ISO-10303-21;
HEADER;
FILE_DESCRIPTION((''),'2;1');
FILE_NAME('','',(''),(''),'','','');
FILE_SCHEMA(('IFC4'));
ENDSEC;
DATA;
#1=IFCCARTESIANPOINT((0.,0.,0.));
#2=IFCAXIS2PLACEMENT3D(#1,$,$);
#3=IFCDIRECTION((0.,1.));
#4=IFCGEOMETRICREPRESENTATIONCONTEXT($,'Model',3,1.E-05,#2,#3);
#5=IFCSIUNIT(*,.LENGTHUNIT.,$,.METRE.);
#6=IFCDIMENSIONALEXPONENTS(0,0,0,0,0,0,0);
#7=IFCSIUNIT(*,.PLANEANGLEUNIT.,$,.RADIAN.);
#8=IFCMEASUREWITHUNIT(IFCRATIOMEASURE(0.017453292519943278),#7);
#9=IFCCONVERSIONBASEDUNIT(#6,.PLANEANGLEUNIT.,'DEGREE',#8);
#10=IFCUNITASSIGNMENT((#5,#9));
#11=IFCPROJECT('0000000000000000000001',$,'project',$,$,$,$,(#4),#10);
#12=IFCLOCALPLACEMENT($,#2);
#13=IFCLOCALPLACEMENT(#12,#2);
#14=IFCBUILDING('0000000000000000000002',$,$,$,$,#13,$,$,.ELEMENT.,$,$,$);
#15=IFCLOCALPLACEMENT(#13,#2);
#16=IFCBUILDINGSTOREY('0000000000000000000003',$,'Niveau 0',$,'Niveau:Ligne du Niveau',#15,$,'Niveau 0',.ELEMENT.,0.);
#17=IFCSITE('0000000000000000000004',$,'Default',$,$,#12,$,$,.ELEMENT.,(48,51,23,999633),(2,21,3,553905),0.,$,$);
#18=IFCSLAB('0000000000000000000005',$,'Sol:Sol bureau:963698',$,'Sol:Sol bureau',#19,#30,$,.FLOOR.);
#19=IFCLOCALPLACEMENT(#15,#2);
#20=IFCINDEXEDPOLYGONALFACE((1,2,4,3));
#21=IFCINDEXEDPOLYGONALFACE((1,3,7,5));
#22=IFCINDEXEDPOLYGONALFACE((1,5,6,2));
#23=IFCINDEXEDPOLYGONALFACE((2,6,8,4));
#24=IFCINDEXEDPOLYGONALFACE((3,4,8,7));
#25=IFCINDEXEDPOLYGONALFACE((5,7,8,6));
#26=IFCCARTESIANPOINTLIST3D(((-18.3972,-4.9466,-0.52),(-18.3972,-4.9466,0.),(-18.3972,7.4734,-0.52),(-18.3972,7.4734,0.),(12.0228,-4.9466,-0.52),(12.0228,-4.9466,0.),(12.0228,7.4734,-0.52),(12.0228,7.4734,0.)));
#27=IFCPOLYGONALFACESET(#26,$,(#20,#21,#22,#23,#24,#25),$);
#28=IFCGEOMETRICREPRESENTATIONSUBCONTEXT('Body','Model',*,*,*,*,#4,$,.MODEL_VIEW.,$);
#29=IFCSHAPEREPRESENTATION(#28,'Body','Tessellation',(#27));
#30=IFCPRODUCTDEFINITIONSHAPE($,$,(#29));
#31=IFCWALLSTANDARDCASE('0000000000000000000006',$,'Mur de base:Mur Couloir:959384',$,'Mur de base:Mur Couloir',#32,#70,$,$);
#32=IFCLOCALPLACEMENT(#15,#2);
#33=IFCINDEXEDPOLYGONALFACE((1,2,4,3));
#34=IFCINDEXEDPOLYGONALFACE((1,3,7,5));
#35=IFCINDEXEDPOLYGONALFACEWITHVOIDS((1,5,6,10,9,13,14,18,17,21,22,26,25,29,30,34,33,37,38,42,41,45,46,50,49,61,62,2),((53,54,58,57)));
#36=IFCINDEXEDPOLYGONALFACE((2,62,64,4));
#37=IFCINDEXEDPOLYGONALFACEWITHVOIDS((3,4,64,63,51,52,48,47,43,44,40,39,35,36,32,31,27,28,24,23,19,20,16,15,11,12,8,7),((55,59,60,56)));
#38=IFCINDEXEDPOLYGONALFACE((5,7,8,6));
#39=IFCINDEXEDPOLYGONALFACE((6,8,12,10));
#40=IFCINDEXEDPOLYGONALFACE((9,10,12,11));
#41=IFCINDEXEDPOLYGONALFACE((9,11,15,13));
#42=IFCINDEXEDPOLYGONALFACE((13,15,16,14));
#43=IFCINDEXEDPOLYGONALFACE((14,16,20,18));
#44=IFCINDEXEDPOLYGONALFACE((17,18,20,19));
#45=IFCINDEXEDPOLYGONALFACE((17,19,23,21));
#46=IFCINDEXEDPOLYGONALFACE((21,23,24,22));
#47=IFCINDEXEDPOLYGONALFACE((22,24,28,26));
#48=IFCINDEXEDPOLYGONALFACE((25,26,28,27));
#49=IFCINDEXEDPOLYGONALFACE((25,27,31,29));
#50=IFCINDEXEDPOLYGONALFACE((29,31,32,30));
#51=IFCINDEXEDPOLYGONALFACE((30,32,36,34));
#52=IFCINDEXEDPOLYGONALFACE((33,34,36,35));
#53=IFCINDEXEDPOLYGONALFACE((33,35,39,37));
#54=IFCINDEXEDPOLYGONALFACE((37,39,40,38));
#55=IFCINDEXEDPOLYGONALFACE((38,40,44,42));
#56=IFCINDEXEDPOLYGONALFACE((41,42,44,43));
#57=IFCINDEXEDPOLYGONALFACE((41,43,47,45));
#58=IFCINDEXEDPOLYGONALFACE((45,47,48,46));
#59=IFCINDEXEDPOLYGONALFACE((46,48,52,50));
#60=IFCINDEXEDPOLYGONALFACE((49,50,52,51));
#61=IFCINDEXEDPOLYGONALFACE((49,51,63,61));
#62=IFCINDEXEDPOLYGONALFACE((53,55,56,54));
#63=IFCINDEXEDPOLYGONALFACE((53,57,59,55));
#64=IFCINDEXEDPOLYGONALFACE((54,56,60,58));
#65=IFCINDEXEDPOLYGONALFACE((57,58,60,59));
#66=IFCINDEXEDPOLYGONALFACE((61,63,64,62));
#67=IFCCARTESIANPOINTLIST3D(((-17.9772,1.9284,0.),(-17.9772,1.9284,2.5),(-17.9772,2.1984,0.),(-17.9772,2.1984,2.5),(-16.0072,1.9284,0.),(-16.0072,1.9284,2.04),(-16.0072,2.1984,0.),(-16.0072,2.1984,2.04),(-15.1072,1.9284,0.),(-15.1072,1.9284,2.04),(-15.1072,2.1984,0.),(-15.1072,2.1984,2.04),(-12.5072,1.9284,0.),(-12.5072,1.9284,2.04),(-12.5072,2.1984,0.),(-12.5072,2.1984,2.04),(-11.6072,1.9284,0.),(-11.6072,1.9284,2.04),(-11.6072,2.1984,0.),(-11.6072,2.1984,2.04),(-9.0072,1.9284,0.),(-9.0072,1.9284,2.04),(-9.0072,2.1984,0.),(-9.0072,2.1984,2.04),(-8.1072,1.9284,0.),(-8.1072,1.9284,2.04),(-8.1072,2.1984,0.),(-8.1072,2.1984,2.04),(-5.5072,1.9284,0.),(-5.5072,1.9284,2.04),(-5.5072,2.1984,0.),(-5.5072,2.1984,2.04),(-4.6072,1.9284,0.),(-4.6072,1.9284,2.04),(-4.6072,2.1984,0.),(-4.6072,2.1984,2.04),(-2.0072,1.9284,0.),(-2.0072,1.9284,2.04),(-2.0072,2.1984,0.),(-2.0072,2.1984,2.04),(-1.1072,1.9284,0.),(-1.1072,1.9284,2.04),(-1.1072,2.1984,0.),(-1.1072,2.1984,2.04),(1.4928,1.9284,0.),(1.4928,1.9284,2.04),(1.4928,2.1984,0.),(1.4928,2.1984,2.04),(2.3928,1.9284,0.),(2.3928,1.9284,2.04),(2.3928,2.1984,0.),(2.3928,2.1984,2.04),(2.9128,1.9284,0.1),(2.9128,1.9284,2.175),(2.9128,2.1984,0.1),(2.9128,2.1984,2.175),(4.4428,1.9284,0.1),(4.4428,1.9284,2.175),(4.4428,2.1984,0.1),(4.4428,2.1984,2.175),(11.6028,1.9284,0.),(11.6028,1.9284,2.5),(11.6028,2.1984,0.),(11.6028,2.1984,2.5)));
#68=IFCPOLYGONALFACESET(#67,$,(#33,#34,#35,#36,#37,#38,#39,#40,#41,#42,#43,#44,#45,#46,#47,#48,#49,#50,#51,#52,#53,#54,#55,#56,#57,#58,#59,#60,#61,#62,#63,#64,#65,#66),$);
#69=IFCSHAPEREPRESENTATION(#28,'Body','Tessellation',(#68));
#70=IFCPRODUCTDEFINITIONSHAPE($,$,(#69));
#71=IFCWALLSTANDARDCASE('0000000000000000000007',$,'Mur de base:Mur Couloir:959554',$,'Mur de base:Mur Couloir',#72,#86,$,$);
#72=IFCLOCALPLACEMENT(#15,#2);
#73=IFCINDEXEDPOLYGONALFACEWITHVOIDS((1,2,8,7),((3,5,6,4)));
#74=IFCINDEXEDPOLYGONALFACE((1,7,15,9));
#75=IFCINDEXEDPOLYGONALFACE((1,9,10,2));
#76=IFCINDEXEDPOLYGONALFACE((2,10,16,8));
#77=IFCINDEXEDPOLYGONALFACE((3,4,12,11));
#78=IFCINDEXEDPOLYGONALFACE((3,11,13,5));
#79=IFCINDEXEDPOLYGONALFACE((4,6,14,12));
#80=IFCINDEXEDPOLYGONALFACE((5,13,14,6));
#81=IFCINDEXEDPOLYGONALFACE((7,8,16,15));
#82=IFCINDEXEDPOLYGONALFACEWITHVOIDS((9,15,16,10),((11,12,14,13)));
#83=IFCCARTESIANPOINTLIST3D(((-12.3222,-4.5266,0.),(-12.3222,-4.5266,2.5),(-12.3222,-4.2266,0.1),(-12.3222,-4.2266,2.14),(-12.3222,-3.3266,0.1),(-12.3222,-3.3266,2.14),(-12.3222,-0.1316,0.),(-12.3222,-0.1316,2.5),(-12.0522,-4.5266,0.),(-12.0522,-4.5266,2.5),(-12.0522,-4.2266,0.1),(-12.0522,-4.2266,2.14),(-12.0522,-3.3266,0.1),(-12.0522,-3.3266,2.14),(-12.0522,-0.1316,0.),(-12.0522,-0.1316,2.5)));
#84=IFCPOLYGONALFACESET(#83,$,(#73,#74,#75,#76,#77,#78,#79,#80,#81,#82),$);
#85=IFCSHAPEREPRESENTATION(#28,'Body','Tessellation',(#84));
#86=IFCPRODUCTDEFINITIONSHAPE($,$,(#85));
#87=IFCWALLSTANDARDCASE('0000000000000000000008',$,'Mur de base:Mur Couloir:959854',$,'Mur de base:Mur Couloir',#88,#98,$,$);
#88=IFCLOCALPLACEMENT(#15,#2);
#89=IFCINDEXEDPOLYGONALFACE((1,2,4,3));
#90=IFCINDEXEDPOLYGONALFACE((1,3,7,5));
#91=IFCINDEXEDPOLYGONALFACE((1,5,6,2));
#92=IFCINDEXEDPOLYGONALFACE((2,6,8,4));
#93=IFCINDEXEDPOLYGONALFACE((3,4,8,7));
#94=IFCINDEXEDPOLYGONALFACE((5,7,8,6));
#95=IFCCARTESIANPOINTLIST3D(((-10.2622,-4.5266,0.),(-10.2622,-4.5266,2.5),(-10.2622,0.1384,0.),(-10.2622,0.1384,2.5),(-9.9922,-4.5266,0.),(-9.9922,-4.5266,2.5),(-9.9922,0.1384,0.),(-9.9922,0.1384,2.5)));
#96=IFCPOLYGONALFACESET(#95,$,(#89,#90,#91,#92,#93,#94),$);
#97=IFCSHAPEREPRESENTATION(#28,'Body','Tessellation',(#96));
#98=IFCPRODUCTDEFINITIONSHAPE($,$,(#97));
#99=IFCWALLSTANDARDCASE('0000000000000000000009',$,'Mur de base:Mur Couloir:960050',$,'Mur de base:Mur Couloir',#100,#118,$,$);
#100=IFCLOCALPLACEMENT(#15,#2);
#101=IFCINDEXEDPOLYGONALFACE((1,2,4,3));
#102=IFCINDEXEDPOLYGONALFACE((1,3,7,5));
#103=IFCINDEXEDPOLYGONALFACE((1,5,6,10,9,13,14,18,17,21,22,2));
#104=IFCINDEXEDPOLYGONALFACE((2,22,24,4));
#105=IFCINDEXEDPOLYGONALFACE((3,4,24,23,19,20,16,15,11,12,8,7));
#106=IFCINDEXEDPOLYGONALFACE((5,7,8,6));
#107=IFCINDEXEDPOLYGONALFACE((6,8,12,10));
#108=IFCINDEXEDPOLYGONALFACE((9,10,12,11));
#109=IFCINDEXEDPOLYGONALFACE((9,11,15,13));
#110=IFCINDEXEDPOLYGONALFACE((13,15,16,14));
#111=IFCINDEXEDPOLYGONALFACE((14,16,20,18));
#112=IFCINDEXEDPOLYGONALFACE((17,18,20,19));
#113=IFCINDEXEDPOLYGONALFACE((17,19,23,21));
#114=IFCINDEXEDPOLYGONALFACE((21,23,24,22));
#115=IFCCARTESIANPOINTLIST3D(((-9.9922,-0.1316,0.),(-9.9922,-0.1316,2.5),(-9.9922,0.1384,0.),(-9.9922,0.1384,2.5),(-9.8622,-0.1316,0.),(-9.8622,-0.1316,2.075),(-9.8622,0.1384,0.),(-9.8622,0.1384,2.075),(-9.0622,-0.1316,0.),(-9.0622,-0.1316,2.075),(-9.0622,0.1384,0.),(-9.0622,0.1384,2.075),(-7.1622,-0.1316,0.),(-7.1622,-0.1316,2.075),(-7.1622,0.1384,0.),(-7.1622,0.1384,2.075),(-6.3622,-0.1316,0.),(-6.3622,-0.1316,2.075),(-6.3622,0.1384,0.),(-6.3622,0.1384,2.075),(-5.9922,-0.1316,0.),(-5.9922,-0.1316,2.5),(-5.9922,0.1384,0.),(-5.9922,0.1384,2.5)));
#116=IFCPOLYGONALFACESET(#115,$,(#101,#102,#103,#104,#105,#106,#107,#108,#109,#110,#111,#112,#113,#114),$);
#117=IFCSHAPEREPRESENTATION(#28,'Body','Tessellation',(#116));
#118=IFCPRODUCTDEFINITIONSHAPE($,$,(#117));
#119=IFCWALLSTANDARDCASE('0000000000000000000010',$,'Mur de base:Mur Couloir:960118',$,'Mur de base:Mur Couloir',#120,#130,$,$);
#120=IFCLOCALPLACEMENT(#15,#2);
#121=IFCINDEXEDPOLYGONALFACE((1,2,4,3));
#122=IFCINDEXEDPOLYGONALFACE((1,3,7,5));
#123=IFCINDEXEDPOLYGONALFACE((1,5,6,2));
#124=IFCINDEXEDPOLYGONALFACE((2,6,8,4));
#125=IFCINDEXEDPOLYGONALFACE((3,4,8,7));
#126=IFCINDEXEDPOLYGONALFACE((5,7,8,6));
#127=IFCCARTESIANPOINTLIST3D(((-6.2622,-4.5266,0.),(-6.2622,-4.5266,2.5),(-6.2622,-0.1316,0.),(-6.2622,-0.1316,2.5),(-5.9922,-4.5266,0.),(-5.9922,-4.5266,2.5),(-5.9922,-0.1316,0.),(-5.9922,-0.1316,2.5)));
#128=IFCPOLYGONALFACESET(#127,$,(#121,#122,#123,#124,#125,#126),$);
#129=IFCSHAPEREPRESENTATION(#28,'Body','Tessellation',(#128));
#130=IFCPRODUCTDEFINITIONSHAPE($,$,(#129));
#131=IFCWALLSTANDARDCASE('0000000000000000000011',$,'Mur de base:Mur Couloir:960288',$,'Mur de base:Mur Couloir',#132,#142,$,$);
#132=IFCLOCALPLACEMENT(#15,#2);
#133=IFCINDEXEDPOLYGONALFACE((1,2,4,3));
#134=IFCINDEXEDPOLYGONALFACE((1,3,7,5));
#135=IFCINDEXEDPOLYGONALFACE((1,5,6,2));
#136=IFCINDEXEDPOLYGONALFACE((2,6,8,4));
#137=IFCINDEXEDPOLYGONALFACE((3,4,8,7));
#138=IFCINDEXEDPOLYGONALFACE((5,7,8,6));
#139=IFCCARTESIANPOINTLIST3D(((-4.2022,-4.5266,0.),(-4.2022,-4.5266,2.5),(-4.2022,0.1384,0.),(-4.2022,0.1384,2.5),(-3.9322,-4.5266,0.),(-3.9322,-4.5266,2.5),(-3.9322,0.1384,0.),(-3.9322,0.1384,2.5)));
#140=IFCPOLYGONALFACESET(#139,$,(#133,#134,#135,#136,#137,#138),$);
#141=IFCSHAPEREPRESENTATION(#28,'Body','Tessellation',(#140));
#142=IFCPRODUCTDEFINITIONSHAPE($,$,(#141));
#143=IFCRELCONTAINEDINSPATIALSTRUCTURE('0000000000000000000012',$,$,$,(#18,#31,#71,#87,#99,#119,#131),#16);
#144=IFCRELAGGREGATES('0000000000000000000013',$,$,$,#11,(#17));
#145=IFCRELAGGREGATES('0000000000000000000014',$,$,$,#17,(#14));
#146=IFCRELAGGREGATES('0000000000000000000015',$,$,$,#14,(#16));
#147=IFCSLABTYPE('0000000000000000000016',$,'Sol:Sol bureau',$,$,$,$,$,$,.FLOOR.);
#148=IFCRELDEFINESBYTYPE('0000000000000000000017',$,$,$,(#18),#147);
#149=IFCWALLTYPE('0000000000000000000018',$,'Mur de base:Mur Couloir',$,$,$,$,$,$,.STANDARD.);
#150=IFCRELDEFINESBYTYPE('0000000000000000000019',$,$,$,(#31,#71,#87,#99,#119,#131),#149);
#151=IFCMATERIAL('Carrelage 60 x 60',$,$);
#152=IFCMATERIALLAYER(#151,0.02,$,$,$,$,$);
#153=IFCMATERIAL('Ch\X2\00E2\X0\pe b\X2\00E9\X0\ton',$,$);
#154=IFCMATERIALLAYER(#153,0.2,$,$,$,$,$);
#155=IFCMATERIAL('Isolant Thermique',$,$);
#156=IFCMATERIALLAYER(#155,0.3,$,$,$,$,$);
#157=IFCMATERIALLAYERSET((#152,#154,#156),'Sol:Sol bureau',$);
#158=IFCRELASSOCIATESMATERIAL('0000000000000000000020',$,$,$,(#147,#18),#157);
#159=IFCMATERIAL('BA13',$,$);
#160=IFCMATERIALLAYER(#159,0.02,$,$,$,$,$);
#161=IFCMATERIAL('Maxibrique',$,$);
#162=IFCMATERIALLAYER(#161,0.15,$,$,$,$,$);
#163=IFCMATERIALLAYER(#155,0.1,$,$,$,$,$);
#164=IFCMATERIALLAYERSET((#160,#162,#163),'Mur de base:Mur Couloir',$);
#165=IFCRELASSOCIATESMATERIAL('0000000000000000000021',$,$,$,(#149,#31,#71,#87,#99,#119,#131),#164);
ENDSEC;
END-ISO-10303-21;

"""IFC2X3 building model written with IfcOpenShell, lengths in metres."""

from ifc_helpers import new_model, entity, si_unit, converted_unit, direction, frame, frame_2d, origin, origin_2d_with_axis, place, context, subcontext, project, spatial, rectangle, extrude, material, layer, layer_set, layer_usage, type_object, element, save


model = new_model("IFC2X3")

# Units and contexts
model_context = context("Model", 3, precision=1e-05, world=origin(), true_north=direction((0.0, 1.0)))
body_context = subcontext(model_context, "Body", "Model", "MODEL_VIEW")
ifc_project = project(units=[si_unit("LENGTHUNIT", "METRE"), converted_unit("PLANEANGLEUNIT", "DEGREE", entity("IfcRatioMeasure", 0.017453292519943278), si_unit("PLANEANGLEUNIT", "RADIAN"), dimensions=[0, 0, 0, 0, 0, 0, 0])], contexts=[model_context])

# Site, building, storey
site_placement = place(None, origin())
site = spatial("IfcSite", under=ifc_project, at=site_placement, Name="Default", CompositionType="ELEMENT", RefLatitude=(48, 51, 23, 999633), RefLongitude=(2, 21, 3, 553905), RefElevation=0.0)
building_placement = place(site_placement, origin())
building = spatial("IfcBuilding", under=site, at=building_placement, CompositionType="ELEMENT")
storey_placement = place(building_placement, origin())
storey = spatial("IfcBuildingStorey", under=building, at=storey_placement, Name="Niveau 0", ObjectType="Niveau:Ligne du Niveau", LongName="Niveau 0", CompositionType="ELEMENT", Elevation=0.0)

# Slab
ifc_material_1 = material(Name="Carrelage 60 x 60")
ifc_layer_1 = layer(ifc_material_1, 0.02)
ifc_material_2 = material(Name="Châpe béton")
ifc_layer_2 = layer(ifc_material_2, 0.2)
ifc_material_3 = material(Name="Isolant Thermique")
ifc_layer_3 = layer(ifc_material_3, 0.3)
ifc_layer_set_1 = layer_set([ifc_layer_1, ifc_layer_2, ifc_layer_3], Name="Sol:Sol bureau")
ifc_layer_usage_1 = layer_usage(ifc_layer_set_1, "AXIS3", "POSITIVE", 0.0)
slab_type = type_object("IfcSlabType", Name="Sol:Sol bureau", PredefinedType="FLOOR", material=ifc_layer_set_1)
slab_placement = place(storey_placement, origin())
element("IfcSlab", 1, at=slab_placement, inside=storey, type_object=slab_type, material=ifc_layer_usage_1, Name="Sol:Sol bureau:963698", ObjectType="Sol:Sol bureau", PredefinedType="FLOOR", context=body_context, shape_type="SweptSolid", body=[
    extrude(rectangle(XDim=12.42, YDim=30.42, at=origin_2d_with_axis()), frame((-3.1872, 1.2634, 0.0), z_axis=(0.0, 0.0, -1.0), x_axis=(0.0, 1.0, 0.0)), (0.0, 0.0, 1.0), 0.52),
])

# Wall, openings
ifc_material_4 = material(Name="BA13")
ifc_layer_4 = layer(ifc_material_4, 0.02)
ifc_material_5 = material(Name="Maxibrique")
ifc_layer_5 = layer(ifc_material_5, 0.15)
ifc_layer_6 = layer(ifc_material_3, 0.1)
ifc_layer_set_2 = layer_set([ifc_layer_4, ifc_layer_5, ifc_layer_6], Name="Mur de base:Mur Couloir")
ifc_layer_usage_2 = layer_usage(ifc_layer_set_2, "AXIS2", "NEGATIVE", 0.135)
wall_type_1 = type_object("IfcWallType", Name="Mur de base:Mur Couloir", PredefinedType="STANDARD", material=ifc_layer_set_2)
wall_1_placement = place(storey_placement, frame((-17.9772, 2.0634, 0.0)))
wall_1 = element("IfcWallStandardCase", 2, at=wall_1_placement, inside=storey, type_object=wall_type_1, material=ifc_layer_usage_2, Name="Mur de base:Mur Couloir:959384", ObjectType="Mur de base:Mur Couloir", context=body_context, shape_type="SweptSolid", body=[
    extrude(rectangle(XDim=29.58, YDim=0.27, at=frame_2d((14.79, 0.0), x_axis=(-1.0, 0.0))), origin(), (0.0, 0.0, 1.0), 2.5),
])
opening_1_placement = place(wall_1_placement, frame((17.9772, -2.0634, 0.0)))
element("IfcOpeningElement", 3, at=opening_1_placement, cuts=wall_1, ObjectType="Opening", context=body_context, shape_type="SweptSolid", body=[
    extrude(rectangle(XDim=2.04, YDim=0.9, at=origin_2d_with_axis()), frame((-15.5572, 1.9284, 1.02), z_axis=(0.0, 1.0, 0.0), x_axis=(0.0, 0.0, -1.0)), (0.0, 0.0, 1.0), 0.27),
])
opening_2_placement = place(wall_1_placement, frame((17.9772, -2.0634, 0.0)))
element("IfcOpeningElement", 4, at=opening_2_placement, cuts=wall_1, ObjectType="Opening", context=body_context, shape_type="SweptSolid", body=[
    extrude(rectangle(XDim=2.04, YDim=0.9, at=origin_2d_with_axis()), frame((-12.0572, 1.9284, 1.02), z_axis=(0.0, 1.0, 0.0), x_axis=(0.0, 0.0, -1.0)), (0.0, 0.0, 1.0), 0.27),
])
opening_3_placement = place(wall_1_placement, frame((17.9772, -2.0634, 0.0)))
element("IfcOpeningElement", 5, at=opening_3_placement, cuts=wall_1, ObjectType="Opening", context=body_context, shape_type="SweptSolid", body=[
    extrude(rectangle(XDim=2.04, YDim=0.9, at=origin_2d_with_axis()), frame((-8.5572, 1.9284, 1.02), z_axis=(0.0, 1.0, 0.0), x_axis=(0.0, 0.0, -1.0)), (0.0, 0.0, 1.0), 0.27),
])
opening_4_placement = place(wall_1_placement, frame((17.9772, -2.0634, 0.0)))
element("IfcOpeningElement", 6, at=opening_4_placement, cuts=wall_1, ObjectType="Opening", context=body_context, shape_type="SweptSolid", body=[
    extrude(rectangle(XDim=2.04, YDim=0.9, at=frame_2d((0.0, 0.0), x_axis=(1.0, 0.0))), frame((-5.0572, 1.9284, 1.02), z_axis=(0.0, 1.0, 0.0), x_axis=(0.0, 0.0, -1.0)), (0.0, 0.0, 1.0), 0.27),
])
opening_5_placement = place(wall_1_placement, frame((17.9772, -2.0634, 0.0)))
element("IfcOpeningElement", 7, at=opening_5_placement, cuts=wall_1, ObjectType="Opening", context=body_context, shape_type="SweptSolid", body=[
    extrude(rectangle(XDim=2.04, YDim=0.9, at=frame_2d((0.0, 0.0), x_axis=(1.0, 0.0))), frame((-1.5572, 1.9284, 1.02), z_axis=(0.0, 1.0, 0.0), x_axis=(0.0, 0.0, -1.0)), (0.0, 0.0, 1.0), 0.27),
])
opening_6_placement = place(wall_1_placement, frame((17.9772, -2.0634, 0.0)))
element("IfcOpeningElement", 8, at=opening_6_placement, cuts=wall_1, ObjectType="Opening", context=body_context, shape_type="SweptSolid", body=[
    extrude(rectangle(XDim=2.04, YDim=0.9, at=frame_2d((0.0, 0.0), x_axis=(1.0, 0.0))), frame((1.9428, 1.9284, 1.02), z_axis=(0.0, 1.0, 0.0), x_axis=(0.0, 0.0, -1.0)), (0.0, 0.0, 1.0), 0.27),
])
opening_7_placement = place(wall_1_placement, frame((20.89, -0.135, 0.1)))
element("IfcOpeningElement", 9, at=opening_7_placement, cuts=wall_1, ObjectType="Opening", context=body_context, shape_type="SweptSolid", body=[
    extrude(rectangle(XDim=2.075, YDim=1.53, at=frame_2d((1.0375, 0.765), x_axis=(1.0, 0.0))), frame((0.0, 0.0, 0.0), z_axis=(0.0, 1.0, 0.0), x_axis=(0.0, 0.0, 1.0)), (0.0, 0.0, 1.0), 0.27),
])

# Wall, opening
ifc_layer_usage_3 = layer_usage(ifc_layer_set_2, "AXIS2", "NEGATIVE", 0.135)
wall_2_placement = place(storey_placement, frame((-12.1872, -0.1316, 0.0), z_axis=(0.0, 0.0, 1.0), x_axis=(0.0, -1.0, 0.0)))
wall_2 = element("IfcWallStandardCase", 10, at=wall_2_placement, inside=storey, type_object=wall_type_1, material=ifc_layer_usage_3, Name="Mur de base:Mur Couloir:959554", ObjectType="Mur de base:Mur Couloir", context=body_context, shape_type="SweptSolid", body=[
    extrude(rectangle(XDim=4.395, YDim=0.27, at=frame_2d((2.1975, 0.0), x_axis=(-1.0, 0.0))), origin(), (0.0, 0.0, 1.0), 2.5),
])
opening_8_placement = place(wall_2_placement, frame((-0.1316, 12.1872, 0.0), z_axis=(0.0, 0.0, 1.0), x_axis=(0.0, 1.0, 0.0)))
element("IfcOpeningElement", 11, at=opening_8_placement, cuts=wall_2, ObjectType="Opening", context=body_context, shape_type="SweptSolid", body=[
    extrude(rectangle(XDim=2.04, YDim=0.9, at=frame_2d((0.0, 0.0), x_axis=(0.0, 1.0))), frame((-12.3222, -3.7766, 1.12), z_axis=(1.0, 0.0, 0.0), x_axis=(0.0, -1.0, 0.0)), (0.0, 0.0, 1.0), 0.27),
])

# Wall
ifc_layer_usage_4 = layer_usage(ifc_layer_set_2, "AXIS2", "NEGATIVE", 0.135)
wall_3_placement = place(storey_placement, frame((-10.1272, -4.5266, 0.0), z_axis=(0.0, 0.0, 1.0), x_axis=(0.0, 1.0, 0.0)))
element("IfcWallStandardCase", 12, at=wall_3_placement, inside=storey, type_object=wall_type_1, material=ifc_layer_usage_4, Name="Mur de base:Mur Couloir:959854", ObjectType="Mur de base:Mur Couloir", context=body_context, shape_type="SweptSolid", body=[
    extrude(rectangle(XDim=4.665, YDim=0.27, at=frame_2d((2.3325, 0.0), x_axis=(-1.0, 0.0))), origin(), (0.0, 0.0, 1.0), 2.5),
])

# Wall, openings
ifc_layer_usage_5 = layer_usage(ifc_layer_set_2, "AXIS2", "NEGATIVE", 0.135)
wall_4_placement = place(storey_placement, frame((-9.9922, 0.0034, 0.0)))
wall_4 = element("IfcWallStandardCase", 13, at=wall_4_placement, inside=storey, type_object=wall_type_1, material=ifc_layer_usage_5, Name="Mur de base:Mur Couloir:960050", ObjectType="Mur de base:Mur Couloir", context=body_context, shape_type="SweptSolid", body=[
    extrude(rectangle(XDim=4.0, YDim=0.27, at=frame_2d((2.0, 0.0), x_axis=(-1.0, 0.0))), origin(), (0.0, 0.0, 1.0), 2.5),
])
opening_9_placement = place(wall_4_placement, frame((0.13, -0.135, 0.0)))
element("IfcOpeningElement", 14, at=opening_9_placement, cuts=wall_4, ObjectType="Opening", context=body_context, shape_type="SweptSolid", body=[
    extrude(rectangle(XDim=2.075, YDim=0.8, at=frame_2d((1.0375, 0.4), x_axis=(1.0, 0.0))), frame((0.0, 0.0, 0.0), z_axis=(0.0, 1.0, 0.0), x_axis=(0.0, 0.0, 1.0)), (0.0, 0.0, 1.0), 0.27),
])
opening_10_placement = place(wall_4_placement, frame((2.83, -0.135, 0.0)))
element("IfcOpeningElement", 15, at=opening_10_placement, cuts=wall_4, ObjectType="Opening", context=body_context, shape_type="SweptSolid", body=[
    extrude(rectangle(XDim=2.075, YDim=0.8, at=frame_2d((1.0375, 0.4), x_axis=(1.0, 0.0))), frame((0.0, 0.0, 0.0), z_axis=(0.0, 1.0, 0.0), x_axis=(0.0, 0.0, 1.0)), (0.0, 0.0, 1.0), 0.27),
])

# Walls
ifc_layer_usage_6 = layer_usage(ifc_layer_set_2, "AXIS2", "NEGATIVE", 0.135)
wall_5_placement = place(storey_placement, frame((-6.1272, -0.1316, 0.0), z_axis=(0.0, 0.0, 1.0), x_axis=(0.0, -1.0, 0.0)))
element("IfcWallStandardCase", 16, at=wall_5_placement, inside=storey, type_object=wall_type_1, material=ifc_layer_usage_6, Name="Mur de base:Mur Couloir:960118", ObjectType="Mur de base:Mur Couloir", context=body_context, shape_type="SweptSolid", body=[
    extrude(rectangle(XDim=4.395, YDim=0.27, at=frame_2d((2.1975, 0.0), x_axis=(-1.0, 0.0))), origin(), (0.0, 0.0, 1.0), 2.5),
])
ifc_layer_usage_7 = layer_usage(ifc_layer_set_2, "AXIS2", "NEGATIVE", 0.135)
wall_6_placement = place(storey_placement, frame((-4.0672, -4.5266, 0.0), z_axis=(0.0, 0.0, 1.0), x_axis=(0.0, 1.0, 0.0)))
element("IfcWallStandardCase", 17, at=wall_6_placement, inside=storey, type_object=wall_type_1, material=ifc_layer_usage_7, Name="Mur de base:Mur Couloir:960288", ObjectType="Mur de base:Mur Couloir", context=body_context, shape_type="SweptSolid", body=[
    extrude(rectangle(XDim=4.665, YDim=0.27, at=frame_2d((2.3325, 0.0), x_axis=(-1.0, 0.0))), origin(), (0.0, 0.0, 1.0), 2.5),
])

save(model, "model.ifc")
